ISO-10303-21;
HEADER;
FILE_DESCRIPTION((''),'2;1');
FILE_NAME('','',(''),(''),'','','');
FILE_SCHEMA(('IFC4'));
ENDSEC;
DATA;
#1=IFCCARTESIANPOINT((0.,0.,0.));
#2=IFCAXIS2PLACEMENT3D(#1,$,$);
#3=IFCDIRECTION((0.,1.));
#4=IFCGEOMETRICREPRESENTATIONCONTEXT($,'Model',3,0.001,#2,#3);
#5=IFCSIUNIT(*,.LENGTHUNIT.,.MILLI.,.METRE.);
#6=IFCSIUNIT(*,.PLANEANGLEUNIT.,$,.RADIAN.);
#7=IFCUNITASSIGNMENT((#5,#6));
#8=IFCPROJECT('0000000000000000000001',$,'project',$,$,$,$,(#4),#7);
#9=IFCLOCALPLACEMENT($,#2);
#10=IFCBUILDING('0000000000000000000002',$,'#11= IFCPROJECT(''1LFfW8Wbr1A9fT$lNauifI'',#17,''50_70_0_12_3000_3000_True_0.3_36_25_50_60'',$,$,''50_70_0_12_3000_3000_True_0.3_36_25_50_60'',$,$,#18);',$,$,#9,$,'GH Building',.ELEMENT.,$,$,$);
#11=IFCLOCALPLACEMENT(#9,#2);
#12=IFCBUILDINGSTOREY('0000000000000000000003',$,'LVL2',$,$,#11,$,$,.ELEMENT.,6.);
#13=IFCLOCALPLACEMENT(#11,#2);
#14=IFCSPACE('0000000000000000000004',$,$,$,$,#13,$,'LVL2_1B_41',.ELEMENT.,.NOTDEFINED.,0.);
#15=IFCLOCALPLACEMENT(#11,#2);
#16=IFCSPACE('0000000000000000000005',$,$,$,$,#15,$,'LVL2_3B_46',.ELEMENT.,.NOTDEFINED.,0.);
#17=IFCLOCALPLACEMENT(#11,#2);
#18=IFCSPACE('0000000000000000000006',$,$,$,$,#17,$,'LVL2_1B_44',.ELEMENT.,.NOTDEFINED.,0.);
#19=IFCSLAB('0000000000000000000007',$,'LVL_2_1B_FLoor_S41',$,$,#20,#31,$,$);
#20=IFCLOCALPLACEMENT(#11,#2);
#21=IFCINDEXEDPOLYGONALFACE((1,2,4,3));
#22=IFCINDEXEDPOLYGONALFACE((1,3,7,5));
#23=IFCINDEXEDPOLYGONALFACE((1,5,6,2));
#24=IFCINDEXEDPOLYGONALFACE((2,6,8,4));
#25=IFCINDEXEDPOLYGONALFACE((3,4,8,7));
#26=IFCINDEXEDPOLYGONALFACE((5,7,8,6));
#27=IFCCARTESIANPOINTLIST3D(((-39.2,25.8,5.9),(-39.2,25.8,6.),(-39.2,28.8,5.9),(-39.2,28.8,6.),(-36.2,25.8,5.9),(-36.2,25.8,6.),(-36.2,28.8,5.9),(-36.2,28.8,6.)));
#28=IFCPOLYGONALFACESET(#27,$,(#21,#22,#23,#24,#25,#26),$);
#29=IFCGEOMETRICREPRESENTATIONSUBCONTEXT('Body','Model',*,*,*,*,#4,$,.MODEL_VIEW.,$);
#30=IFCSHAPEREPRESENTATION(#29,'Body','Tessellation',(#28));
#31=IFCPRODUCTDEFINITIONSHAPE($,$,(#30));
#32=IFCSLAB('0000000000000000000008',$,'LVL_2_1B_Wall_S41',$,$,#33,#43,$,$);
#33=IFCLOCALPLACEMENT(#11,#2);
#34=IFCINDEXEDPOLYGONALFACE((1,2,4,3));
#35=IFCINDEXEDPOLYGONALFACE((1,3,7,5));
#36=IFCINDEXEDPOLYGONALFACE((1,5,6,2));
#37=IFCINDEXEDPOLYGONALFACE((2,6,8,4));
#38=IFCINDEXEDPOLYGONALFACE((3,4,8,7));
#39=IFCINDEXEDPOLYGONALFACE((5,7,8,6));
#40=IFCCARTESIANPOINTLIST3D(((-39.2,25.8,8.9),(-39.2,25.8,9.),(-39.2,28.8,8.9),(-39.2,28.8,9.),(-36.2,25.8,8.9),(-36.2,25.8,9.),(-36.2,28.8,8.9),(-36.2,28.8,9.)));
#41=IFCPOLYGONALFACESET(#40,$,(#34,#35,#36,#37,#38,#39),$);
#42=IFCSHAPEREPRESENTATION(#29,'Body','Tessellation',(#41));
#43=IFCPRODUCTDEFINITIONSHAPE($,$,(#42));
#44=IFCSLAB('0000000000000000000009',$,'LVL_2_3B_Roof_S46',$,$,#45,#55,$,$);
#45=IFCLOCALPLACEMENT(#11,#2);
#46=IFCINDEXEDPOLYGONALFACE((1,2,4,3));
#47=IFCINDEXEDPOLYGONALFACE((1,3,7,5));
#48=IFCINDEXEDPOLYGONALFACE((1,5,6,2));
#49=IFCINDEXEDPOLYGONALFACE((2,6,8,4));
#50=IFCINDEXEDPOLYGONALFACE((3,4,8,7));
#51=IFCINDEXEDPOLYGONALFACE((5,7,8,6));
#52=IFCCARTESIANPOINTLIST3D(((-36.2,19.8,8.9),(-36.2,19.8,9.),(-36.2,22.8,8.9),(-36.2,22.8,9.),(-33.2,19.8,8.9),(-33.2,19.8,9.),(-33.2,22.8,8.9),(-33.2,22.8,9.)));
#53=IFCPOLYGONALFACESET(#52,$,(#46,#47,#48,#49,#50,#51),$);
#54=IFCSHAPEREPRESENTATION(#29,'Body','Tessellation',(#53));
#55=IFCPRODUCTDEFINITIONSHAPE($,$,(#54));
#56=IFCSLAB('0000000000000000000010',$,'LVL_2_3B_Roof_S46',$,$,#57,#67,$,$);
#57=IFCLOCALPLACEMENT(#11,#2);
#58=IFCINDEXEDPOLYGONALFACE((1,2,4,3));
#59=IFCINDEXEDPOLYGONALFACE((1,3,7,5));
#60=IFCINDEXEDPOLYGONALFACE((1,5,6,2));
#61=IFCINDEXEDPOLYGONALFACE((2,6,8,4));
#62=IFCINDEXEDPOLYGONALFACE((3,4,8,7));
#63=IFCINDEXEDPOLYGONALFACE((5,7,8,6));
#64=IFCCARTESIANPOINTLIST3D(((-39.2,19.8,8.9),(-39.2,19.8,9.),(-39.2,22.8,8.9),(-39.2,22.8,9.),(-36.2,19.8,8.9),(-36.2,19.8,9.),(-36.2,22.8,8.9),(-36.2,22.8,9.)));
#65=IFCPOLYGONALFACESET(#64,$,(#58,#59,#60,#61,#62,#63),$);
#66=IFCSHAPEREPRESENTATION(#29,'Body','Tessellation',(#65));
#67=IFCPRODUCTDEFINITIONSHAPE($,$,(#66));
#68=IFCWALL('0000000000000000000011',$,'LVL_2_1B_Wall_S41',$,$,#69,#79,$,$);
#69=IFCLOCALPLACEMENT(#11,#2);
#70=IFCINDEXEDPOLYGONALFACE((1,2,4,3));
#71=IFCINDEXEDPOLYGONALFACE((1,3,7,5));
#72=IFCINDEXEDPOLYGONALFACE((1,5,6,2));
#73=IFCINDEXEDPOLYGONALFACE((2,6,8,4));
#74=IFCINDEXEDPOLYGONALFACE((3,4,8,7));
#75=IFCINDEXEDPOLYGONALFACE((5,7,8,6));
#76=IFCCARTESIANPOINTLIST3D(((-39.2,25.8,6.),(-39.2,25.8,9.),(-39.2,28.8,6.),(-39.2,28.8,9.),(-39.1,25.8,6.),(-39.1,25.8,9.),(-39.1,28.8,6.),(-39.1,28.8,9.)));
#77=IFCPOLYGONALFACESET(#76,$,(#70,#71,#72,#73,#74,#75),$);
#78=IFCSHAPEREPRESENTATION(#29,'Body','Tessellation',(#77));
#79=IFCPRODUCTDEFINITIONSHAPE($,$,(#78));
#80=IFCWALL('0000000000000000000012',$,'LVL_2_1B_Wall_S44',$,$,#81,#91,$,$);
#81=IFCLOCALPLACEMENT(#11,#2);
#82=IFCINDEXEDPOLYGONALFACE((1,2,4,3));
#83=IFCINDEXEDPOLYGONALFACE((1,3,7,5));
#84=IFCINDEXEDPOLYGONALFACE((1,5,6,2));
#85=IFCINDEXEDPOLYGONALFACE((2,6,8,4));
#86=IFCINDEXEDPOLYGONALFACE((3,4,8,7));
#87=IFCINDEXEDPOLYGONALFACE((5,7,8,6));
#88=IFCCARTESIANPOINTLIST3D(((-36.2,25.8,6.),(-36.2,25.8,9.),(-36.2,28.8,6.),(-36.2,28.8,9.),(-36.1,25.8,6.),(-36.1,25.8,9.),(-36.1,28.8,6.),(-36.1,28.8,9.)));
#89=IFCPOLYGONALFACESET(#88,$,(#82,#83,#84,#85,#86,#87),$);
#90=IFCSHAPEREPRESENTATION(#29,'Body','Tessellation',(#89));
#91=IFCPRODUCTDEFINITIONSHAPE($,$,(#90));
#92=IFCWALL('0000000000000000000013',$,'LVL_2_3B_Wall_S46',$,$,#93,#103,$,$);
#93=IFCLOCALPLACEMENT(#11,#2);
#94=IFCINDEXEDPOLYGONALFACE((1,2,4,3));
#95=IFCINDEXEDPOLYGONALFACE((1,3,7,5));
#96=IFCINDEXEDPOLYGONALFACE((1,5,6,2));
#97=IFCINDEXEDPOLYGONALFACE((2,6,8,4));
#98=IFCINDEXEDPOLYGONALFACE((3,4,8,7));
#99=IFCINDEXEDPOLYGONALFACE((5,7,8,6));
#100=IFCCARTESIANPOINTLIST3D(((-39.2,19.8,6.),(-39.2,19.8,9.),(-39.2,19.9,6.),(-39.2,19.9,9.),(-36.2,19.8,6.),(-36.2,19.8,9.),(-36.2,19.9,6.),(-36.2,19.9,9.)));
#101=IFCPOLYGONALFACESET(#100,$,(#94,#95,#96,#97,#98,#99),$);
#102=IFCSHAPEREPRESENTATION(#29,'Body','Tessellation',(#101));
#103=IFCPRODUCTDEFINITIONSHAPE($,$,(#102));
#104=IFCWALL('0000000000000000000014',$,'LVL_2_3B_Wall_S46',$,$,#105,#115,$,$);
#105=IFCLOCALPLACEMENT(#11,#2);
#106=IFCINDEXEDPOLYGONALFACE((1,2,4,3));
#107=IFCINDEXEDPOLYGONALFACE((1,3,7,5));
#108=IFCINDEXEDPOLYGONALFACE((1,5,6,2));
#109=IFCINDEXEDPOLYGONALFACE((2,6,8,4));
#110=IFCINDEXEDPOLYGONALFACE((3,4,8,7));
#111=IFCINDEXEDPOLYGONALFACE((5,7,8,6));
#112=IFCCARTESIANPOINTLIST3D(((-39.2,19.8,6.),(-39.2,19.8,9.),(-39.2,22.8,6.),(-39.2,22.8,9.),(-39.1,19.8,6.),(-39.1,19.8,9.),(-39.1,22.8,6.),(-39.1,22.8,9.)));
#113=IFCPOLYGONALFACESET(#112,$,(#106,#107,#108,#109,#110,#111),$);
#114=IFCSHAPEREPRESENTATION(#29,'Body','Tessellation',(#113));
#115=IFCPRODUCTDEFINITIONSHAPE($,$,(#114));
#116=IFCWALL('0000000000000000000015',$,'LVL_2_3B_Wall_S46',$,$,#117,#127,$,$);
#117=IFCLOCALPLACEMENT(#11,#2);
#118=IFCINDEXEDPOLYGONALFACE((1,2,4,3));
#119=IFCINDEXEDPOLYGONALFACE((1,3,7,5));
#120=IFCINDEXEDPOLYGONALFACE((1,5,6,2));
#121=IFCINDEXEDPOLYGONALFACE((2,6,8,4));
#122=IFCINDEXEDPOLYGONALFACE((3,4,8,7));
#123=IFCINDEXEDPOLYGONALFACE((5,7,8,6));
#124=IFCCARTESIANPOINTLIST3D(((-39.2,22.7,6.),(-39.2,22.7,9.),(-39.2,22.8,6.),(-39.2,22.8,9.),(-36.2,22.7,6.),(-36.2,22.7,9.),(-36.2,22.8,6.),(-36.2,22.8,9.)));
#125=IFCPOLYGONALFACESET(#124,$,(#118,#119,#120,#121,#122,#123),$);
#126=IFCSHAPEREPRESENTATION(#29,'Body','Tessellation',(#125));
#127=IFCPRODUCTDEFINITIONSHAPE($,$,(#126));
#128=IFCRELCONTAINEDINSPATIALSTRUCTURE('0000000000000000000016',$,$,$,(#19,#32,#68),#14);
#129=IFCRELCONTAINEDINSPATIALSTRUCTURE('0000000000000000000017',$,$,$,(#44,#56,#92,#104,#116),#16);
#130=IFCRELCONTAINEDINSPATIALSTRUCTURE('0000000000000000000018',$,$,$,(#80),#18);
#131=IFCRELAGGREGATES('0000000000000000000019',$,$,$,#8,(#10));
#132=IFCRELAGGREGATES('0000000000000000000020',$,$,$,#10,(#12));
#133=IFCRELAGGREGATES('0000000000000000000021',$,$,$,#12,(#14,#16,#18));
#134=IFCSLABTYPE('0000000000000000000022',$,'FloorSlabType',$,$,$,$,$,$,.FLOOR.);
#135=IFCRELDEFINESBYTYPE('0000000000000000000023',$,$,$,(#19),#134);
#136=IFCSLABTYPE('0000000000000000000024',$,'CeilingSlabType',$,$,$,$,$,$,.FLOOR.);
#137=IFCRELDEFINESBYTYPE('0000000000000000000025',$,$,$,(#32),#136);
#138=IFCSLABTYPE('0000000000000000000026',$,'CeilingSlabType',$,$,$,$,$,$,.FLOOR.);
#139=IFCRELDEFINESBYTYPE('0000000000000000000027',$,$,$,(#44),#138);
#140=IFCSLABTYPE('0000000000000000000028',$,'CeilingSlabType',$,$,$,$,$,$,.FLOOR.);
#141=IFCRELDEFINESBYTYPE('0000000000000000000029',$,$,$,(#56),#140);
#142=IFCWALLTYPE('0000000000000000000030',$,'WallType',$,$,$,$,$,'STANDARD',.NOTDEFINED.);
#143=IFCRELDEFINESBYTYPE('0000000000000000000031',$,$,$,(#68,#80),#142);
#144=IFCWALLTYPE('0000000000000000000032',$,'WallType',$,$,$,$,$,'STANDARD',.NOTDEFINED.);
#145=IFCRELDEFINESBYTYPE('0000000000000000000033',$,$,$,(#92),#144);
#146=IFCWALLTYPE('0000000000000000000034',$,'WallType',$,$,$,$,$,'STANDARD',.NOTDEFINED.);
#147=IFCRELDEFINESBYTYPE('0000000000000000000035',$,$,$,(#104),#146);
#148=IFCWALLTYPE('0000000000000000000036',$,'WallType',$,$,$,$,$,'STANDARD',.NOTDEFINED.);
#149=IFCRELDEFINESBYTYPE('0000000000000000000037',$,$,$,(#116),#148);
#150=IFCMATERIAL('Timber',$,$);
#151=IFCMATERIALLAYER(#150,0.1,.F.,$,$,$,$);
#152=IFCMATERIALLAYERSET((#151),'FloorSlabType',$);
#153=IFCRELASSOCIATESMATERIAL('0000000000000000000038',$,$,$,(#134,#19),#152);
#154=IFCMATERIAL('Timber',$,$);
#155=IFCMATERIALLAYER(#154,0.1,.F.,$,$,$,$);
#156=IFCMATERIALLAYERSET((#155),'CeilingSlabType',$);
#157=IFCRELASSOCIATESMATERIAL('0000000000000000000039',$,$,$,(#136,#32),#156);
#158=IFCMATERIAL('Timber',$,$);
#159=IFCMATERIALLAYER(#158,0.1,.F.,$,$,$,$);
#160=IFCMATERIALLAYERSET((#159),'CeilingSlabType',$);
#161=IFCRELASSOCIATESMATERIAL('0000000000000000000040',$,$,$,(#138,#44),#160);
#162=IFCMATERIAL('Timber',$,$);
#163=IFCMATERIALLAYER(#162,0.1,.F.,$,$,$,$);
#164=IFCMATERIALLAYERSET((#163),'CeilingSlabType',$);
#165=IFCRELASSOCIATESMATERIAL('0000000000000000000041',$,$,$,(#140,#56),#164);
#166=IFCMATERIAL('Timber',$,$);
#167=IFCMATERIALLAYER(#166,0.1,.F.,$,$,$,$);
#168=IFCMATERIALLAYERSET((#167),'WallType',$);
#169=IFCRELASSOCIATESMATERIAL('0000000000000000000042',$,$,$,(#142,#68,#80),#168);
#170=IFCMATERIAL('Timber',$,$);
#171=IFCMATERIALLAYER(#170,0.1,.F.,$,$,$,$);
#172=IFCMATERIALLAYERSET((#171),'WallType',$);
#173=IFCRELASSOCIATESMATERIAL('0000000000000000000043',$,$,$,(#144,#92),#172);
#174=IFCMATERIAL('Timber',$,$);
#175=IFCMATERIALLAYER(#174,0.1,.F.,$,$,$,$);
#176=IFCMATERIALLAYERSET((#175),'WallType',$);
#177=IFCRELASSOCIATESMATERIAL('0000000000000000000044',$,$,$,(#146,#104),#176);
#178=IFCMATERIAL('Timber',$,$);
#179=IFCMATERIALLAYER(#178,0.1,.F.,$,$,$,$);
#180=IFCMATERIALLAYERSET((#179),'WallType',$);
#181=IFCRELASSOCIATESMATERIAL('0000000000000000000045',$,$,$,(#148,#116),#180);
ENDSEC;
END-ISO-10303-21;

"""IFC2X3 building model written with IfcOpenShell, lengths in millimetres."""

from ifc_helpers import new_model, si_unit, direction, frame, frame_2d, origin, place, context, subcontext, project, spatial, rectangle, extrude, material, layer, layer_set, layer_usage, type_object, element, save


model = new_model("IFC2X3")

# Units and contexts
model_context = context("Model", 3, precision=0.001, world=origin(), true_north=direction((0.0, 1.0)))
body_context = subcontext(model_context, "Body", "Model", "MODEL_VIEW")
ifc_project = project(units=[si_unit("LENGTHUNIT", "METRE", prefix="MILLI"), si_unit("PLANEANGLEUNIT", "RADIAN")], contexts=[model_context])

# Building, storey
building_placement = place(None, origin())
building = spatial("IfcBuilding", under=ifc_project, at=building_placement, Name="#11= IFCPROJECT('1LFfW8Wbr1A9fT$lNauifI',#17,'50_70_0_12_3000_3000_True_0.3_36_25_50_60',$,$,'50_70_0_12_3000_3000_True_0.3_36_25_50_60',$,$,#18);", LongName="GH Building", CompositionType="ELEMENT")
storey_placement = place(building_placement, origin())
storey = spatial("IfcBuildingStorey", under=building, at=storey_placement, Name="LVL2", CompositionType="ELEMENT", Elevation=6.0)

# Shared definitions
space_1_placement = place(storey_placement, origin())
space_1 = spatial("IfcSpace", under=storey, at=space_1_placement, LongName="LVL2_1B_41", CompositionType="ELEMENT", InteriorOrExteriorSpace="NOTDEFINED", ElevationWithFlooring=0.0)

# Slabs
ifc_material_1 = material(Name="Timber")
ifc_layer_1 = layer(ifc_material_1, 0.1, ventilated=False)
ifc_layer_set_1 = layer_set([ifc_layer_1], Name="FloorSlabType")
ifc_layer_usage_1 = layer_usage(ifc_layer_set_1, "AXIS3", "NEGATIVE", -0.1)
slab_type_1 = type_object("IfcSlabType", Name="FloorSlabType", PredefinedType="FLOOR", material=ifc_layer_set_1)
slab_1_placement = place(space_1_placement, frame((-36.2, 25.8, 5.9), z_axis=(0.0, 0.0, 1.0), x_axis=(0.0, 1.0, 0.0)))
element("IfcSlab", 1, at=slab_1_placement, inside=space_1, type_object=slab_type_1, material=ifc_layer_usage_1, Name="LVL_2_1B_FLoor_S41", context=body_context, shape_type="SweptSolid", body=[
    extrude(rectangle(XDim=3.0, YDim=3.0, at=frame_2d((1.5, 1.5))), origin(), (0.0, 0.0, 1.0), 0.1),
])
ifc_material_2 = material(Name="Timber")
ifc_layer_2 = layer(ifc_material_2, 0.1, ventilated=False)
ifc_layer_set_2 = layer_set([ifc_layer_2], Name="CeilingSlabType")
ifc_layer_usage_2 = layer_usage(ifc_layer_set_2, "AXIS3", "NEGATIVE", -0.1)
slab_type_2 = type_object("IfcSlabType", Name="CeilingSlabType", PredefinedType="FLOOR", material=ifc_layer_set_2)
slab_2_placement = place(space_1_placement, frame((-36.2, 25.8, 8.9), z_axis=(0.0, 0.0, 1.0), x_axis=(0.0, 1.0, 0.0)))
element("IfcSlab", 2, at=slab_2_placement, inside=space_1, type_object=slab_type_2, material=ifc_layer_usage_2, Name="LVL_2_1B_Wall_S41", context=body_context, shape_type="SweptSolid", body=[
    extrude(rectangle(XDim=3.0, YDim=3.0, at=frame_2d((1.5, 1.5))), origin(), (0.0, 0.0, 1.0), 0.1),
])

# Shared definitions
space_2_placement = place(storey_placement, origin())
space_2 = spatial("IfcSpace", under=storey, at=space_2_placement, LongName="LVL2_3B_46", CompositionType="ELEMENT", InteriorOrExteriorSpace="NOTDEFINED", ElevationWithFlooring=0.0)

# Slabs
ifc_material_3 = material(Name="Timber")
ifc_layer_3 = layer(ifc_material_3, 0.1, ventilated=False)
ifc_layer_set_3 = layer_set([ifc_layer_3], Name="CeilingSlabType")
ifc_layer_usage_3 = layer_usage(ifc_layer_set_3, "AXIS3", "NEGATIVE", -0.1)
slab_type_3 = type_object("IfcSlabType", Name="CeilingSlabType", PredefinedType="FLOOR", material=ifc_layer_set_3)
slab_3_placement = place(space_2_placement, frame((-36.2, 19.8, 8.9)))
element("IfcSlab", 3, at=slab_3_placement, inside=space_2, type_object=slab_type_3, material=ifc_layer_usage_3, Name="LVL_2_3B_Roof_S46", context=body_context, shape_type="SweptSolid", body=[
    extrude(rectangle(XDim=3.0, YDim=3.0, at=frame_2d((1.5, 1.5))), origin(), (0.0, 0.0, 1.0), 0.1),
])
ifc_material_4 = material(Name="Timber")
ifc_layer_4 = layer(ifc_material_4, 0.1, ventilated=False)
ifc_layer_set_4 = layer_set([ifc_layer_4], Name="CeilingSlabType")
ifc_layer_usage_4 = layer_usage(ifc_layer_set_4, "AXIS3", "NEGATIVE", -0.1)
slab_type_4 = type_object("IfcSlabType", Name="CeilingSlabType", PredefinedType="FLOOR", material=ifc_layer_set_4)
slab_4_placement = place(space_2_placement, frame((-39.2, 19.8, 8.9)))
element("IfcSlab", 4, at=slab_4_placement, inside=space_2, type_object=slab_type_4, material=ifc_layer_usage_4, Name="LVL_2_3B_Roof_S46", context=body_context, shape_type="SweptSolid", body=[
    extrude(rectangle(XDim=3.0, YDim=3.0, at=frame_2d((1.5, 1.5))), origin(), (0.0, 0.0, 1.0), 0.1),
])

# Wall
ifc_material_5 = material(Name="Timber")
ifc_layer_5 = layer(ifc_material_5, 0.1, ventilated=False)
ifc_layer_set_5 = layer_set([ifc_layer_5], Name="WallType")
ifc_layer_usage_5 = layer_usage(ifc_layer_set_5, "AXIS2", "NEGATIVE", 0.0)
wall_type_1 = type_object("IfcWallType", Name="WallType", ElementType="STANDARD", PredefinedType="NOTDEFINED", material=ifc_layer_set_5)
wall_1_placement = place(space_1_placement, frame((-39.2, 25.8, 6.0), z_axis=(0.0, 0.0, 1.0), x_axis=(0.0, 1.0, 0.0)))
element("IfcWall", 5, at=wall_1_placement, inside=space_1, type_object=wall_type_1, material=ifc_layer_usage_5, Name="LVL_2_1B_Wall_S41", context=body_context, shape_type="SweptSolid", body=[
    extrude(rectangle(XDim=3.0, YDim=0.1, at=frame_2d((1.5, -0.1))), origin(), (0.0, 0.0, 1.0), 3.0),
])

# Shared definitions
space_3_placement = place(storey_placement, origin())
space_3 = spatial("IfcSpace", under=storey, at=space_3_placement, LongName="LVL2_1B_44", CompositionType="ELEMENT", InteriorOrExteriorSpace="NOTDEFINED", ElevationWithFlooring=0.0)

# Wall
ifc_layer_usage_6 = layer_usage(ifc_layer_set_5, "AXIS2", "NEGATIVE", 0.0)
wall_2_placement = place(space_3_placement, frame((-36.2, 25.8, 6.0), z_axis=(0.0, 0.0, 1.0), x_axis=(0.0, 1.0, 0.0)))
element("IfcWall", 6, at=wall_2_placement, inside=space_3, type_object=wall_type_1, material=ifc_layer_usage_6, Name="LVL_2_1B_Wall_S44", context=body_context, shape_type="SweptSolid", body=[
    extrude(rectangle(XDim=3.0, YDim=0.1, at=frame_2d((1.5, -0.1))), origin(), (0.0, 0.0, 1.0), 3.0),
])

# Walls
ifc_material_6 = material(Name="Timber")
ifc_layer_6 = layer(ifc_material_6, 0.1, ventilated=False)
ifc_layer_set_6 = layer_set([ifc_layer_6], Name="WallType")
ifc_layer_usage_7 = layer_usage(ifc_layer_set_6, "AXIS2", "NEGATIVE", 0.0)
wall_type_2 = type_object("IfcWallType", Name="WallType", ElementType="STANDARD", PredefinedType="NOTDEFINED", material=ifc_layer_set_6)
wall_3_placement = place(space_2_placement, frame((-36.2, 19.8, 6.0), z_axis=(0.0, 0.0, 1.0), x_axis=(-1.0, 0.0, 0.0)))
element("IfcWall", 7, at=wall_3_placement, inside=space_2, type_object=wall_type_2, material=ifc_layer_usage_7, Name="LVL_2_3B_Wall_S46", context=body_context, shape_type="SweptSolid", body=[
    extrude(rectangle(XDim=3.0, YDim=0.1, at=frame_2d((1.5, -0.1))), origin(), (0.0, 0.0, 1.0), 3.0),
])
ifc_material_7 = material(Name="Timber")
ifc_layer_7 = layer(ifc_material_7, 0.1, ventilated=False)
ifc_layer_set_7 = layer_set([ifc_layer_7], Name="WallType")
ifc_layer_usage_8 = layer_usage(ifc_layer_set_7, "AXIS2", "NEGATIVE", 0.0)
wall_type_3 = type_object("IfcWallType", Name="WallType", ElementType="STANDARD", PredefinedType="NOTDEFINED", material=ifc_layer_set_7)
wall_4_placement = place(space_2_placement, frame((-39.2, 19.8, 6.0), z_axis=(0.0, 0.0, 1.0), x_axis=(0.0, 1.0, 0.0)))
element("IfcWall", 8, at=wall_4_placement, inside=space_2, type_object=wall_type_3, material=ifc_layer_usage_8, Name="LVL_2_3B_Wall_S46", context=body_context, shape_type="SweptSolid", body=[
    extrude(rectangle(XDim=3.0, YDim=0.1, at=frame_2d((1.5, -0.1))), origin(), (0.0, 0.0, 1.0), 3.0),
])
ifc_material_8 = material(Name="Timber")
ifc_layer_8 = layer(ifc_material_8, 0.1, ventilated=False)
ifc_layer_set_8 = layer_set([ifc_layer_8], Name="WallType")
ifc_layer_usage_9 = layer_usage(ifc_layer_set_8, "AXIS2", "NEGATIVE", 0.0)
wall_type_4 = type_object("IfcWallType", Name="WallType", ElementType="STANDARD", PredefinedType="NOTDEFINED", material=ifc_layer_set_8)
wall_5_placement = place(space_2_placement, frame((-39.2, 22.8, 6.0)))
element("IfcWall", 9, at=wall_5_placement, inside=space_2, type_object=wall_type_4, material=ifc_layer_usage_9, Name="LVL_2_3B_Wall_S46", context=body_context, shape_type="SweptSolid", body=[
    extrude(rectangle(XDim=3.0, YDim=0.1, at=frame_2d((1.5, -0.1))), origin(), (0.0, 0.0, 1.0), 3.0),
])

save(model, "model.ifc")
